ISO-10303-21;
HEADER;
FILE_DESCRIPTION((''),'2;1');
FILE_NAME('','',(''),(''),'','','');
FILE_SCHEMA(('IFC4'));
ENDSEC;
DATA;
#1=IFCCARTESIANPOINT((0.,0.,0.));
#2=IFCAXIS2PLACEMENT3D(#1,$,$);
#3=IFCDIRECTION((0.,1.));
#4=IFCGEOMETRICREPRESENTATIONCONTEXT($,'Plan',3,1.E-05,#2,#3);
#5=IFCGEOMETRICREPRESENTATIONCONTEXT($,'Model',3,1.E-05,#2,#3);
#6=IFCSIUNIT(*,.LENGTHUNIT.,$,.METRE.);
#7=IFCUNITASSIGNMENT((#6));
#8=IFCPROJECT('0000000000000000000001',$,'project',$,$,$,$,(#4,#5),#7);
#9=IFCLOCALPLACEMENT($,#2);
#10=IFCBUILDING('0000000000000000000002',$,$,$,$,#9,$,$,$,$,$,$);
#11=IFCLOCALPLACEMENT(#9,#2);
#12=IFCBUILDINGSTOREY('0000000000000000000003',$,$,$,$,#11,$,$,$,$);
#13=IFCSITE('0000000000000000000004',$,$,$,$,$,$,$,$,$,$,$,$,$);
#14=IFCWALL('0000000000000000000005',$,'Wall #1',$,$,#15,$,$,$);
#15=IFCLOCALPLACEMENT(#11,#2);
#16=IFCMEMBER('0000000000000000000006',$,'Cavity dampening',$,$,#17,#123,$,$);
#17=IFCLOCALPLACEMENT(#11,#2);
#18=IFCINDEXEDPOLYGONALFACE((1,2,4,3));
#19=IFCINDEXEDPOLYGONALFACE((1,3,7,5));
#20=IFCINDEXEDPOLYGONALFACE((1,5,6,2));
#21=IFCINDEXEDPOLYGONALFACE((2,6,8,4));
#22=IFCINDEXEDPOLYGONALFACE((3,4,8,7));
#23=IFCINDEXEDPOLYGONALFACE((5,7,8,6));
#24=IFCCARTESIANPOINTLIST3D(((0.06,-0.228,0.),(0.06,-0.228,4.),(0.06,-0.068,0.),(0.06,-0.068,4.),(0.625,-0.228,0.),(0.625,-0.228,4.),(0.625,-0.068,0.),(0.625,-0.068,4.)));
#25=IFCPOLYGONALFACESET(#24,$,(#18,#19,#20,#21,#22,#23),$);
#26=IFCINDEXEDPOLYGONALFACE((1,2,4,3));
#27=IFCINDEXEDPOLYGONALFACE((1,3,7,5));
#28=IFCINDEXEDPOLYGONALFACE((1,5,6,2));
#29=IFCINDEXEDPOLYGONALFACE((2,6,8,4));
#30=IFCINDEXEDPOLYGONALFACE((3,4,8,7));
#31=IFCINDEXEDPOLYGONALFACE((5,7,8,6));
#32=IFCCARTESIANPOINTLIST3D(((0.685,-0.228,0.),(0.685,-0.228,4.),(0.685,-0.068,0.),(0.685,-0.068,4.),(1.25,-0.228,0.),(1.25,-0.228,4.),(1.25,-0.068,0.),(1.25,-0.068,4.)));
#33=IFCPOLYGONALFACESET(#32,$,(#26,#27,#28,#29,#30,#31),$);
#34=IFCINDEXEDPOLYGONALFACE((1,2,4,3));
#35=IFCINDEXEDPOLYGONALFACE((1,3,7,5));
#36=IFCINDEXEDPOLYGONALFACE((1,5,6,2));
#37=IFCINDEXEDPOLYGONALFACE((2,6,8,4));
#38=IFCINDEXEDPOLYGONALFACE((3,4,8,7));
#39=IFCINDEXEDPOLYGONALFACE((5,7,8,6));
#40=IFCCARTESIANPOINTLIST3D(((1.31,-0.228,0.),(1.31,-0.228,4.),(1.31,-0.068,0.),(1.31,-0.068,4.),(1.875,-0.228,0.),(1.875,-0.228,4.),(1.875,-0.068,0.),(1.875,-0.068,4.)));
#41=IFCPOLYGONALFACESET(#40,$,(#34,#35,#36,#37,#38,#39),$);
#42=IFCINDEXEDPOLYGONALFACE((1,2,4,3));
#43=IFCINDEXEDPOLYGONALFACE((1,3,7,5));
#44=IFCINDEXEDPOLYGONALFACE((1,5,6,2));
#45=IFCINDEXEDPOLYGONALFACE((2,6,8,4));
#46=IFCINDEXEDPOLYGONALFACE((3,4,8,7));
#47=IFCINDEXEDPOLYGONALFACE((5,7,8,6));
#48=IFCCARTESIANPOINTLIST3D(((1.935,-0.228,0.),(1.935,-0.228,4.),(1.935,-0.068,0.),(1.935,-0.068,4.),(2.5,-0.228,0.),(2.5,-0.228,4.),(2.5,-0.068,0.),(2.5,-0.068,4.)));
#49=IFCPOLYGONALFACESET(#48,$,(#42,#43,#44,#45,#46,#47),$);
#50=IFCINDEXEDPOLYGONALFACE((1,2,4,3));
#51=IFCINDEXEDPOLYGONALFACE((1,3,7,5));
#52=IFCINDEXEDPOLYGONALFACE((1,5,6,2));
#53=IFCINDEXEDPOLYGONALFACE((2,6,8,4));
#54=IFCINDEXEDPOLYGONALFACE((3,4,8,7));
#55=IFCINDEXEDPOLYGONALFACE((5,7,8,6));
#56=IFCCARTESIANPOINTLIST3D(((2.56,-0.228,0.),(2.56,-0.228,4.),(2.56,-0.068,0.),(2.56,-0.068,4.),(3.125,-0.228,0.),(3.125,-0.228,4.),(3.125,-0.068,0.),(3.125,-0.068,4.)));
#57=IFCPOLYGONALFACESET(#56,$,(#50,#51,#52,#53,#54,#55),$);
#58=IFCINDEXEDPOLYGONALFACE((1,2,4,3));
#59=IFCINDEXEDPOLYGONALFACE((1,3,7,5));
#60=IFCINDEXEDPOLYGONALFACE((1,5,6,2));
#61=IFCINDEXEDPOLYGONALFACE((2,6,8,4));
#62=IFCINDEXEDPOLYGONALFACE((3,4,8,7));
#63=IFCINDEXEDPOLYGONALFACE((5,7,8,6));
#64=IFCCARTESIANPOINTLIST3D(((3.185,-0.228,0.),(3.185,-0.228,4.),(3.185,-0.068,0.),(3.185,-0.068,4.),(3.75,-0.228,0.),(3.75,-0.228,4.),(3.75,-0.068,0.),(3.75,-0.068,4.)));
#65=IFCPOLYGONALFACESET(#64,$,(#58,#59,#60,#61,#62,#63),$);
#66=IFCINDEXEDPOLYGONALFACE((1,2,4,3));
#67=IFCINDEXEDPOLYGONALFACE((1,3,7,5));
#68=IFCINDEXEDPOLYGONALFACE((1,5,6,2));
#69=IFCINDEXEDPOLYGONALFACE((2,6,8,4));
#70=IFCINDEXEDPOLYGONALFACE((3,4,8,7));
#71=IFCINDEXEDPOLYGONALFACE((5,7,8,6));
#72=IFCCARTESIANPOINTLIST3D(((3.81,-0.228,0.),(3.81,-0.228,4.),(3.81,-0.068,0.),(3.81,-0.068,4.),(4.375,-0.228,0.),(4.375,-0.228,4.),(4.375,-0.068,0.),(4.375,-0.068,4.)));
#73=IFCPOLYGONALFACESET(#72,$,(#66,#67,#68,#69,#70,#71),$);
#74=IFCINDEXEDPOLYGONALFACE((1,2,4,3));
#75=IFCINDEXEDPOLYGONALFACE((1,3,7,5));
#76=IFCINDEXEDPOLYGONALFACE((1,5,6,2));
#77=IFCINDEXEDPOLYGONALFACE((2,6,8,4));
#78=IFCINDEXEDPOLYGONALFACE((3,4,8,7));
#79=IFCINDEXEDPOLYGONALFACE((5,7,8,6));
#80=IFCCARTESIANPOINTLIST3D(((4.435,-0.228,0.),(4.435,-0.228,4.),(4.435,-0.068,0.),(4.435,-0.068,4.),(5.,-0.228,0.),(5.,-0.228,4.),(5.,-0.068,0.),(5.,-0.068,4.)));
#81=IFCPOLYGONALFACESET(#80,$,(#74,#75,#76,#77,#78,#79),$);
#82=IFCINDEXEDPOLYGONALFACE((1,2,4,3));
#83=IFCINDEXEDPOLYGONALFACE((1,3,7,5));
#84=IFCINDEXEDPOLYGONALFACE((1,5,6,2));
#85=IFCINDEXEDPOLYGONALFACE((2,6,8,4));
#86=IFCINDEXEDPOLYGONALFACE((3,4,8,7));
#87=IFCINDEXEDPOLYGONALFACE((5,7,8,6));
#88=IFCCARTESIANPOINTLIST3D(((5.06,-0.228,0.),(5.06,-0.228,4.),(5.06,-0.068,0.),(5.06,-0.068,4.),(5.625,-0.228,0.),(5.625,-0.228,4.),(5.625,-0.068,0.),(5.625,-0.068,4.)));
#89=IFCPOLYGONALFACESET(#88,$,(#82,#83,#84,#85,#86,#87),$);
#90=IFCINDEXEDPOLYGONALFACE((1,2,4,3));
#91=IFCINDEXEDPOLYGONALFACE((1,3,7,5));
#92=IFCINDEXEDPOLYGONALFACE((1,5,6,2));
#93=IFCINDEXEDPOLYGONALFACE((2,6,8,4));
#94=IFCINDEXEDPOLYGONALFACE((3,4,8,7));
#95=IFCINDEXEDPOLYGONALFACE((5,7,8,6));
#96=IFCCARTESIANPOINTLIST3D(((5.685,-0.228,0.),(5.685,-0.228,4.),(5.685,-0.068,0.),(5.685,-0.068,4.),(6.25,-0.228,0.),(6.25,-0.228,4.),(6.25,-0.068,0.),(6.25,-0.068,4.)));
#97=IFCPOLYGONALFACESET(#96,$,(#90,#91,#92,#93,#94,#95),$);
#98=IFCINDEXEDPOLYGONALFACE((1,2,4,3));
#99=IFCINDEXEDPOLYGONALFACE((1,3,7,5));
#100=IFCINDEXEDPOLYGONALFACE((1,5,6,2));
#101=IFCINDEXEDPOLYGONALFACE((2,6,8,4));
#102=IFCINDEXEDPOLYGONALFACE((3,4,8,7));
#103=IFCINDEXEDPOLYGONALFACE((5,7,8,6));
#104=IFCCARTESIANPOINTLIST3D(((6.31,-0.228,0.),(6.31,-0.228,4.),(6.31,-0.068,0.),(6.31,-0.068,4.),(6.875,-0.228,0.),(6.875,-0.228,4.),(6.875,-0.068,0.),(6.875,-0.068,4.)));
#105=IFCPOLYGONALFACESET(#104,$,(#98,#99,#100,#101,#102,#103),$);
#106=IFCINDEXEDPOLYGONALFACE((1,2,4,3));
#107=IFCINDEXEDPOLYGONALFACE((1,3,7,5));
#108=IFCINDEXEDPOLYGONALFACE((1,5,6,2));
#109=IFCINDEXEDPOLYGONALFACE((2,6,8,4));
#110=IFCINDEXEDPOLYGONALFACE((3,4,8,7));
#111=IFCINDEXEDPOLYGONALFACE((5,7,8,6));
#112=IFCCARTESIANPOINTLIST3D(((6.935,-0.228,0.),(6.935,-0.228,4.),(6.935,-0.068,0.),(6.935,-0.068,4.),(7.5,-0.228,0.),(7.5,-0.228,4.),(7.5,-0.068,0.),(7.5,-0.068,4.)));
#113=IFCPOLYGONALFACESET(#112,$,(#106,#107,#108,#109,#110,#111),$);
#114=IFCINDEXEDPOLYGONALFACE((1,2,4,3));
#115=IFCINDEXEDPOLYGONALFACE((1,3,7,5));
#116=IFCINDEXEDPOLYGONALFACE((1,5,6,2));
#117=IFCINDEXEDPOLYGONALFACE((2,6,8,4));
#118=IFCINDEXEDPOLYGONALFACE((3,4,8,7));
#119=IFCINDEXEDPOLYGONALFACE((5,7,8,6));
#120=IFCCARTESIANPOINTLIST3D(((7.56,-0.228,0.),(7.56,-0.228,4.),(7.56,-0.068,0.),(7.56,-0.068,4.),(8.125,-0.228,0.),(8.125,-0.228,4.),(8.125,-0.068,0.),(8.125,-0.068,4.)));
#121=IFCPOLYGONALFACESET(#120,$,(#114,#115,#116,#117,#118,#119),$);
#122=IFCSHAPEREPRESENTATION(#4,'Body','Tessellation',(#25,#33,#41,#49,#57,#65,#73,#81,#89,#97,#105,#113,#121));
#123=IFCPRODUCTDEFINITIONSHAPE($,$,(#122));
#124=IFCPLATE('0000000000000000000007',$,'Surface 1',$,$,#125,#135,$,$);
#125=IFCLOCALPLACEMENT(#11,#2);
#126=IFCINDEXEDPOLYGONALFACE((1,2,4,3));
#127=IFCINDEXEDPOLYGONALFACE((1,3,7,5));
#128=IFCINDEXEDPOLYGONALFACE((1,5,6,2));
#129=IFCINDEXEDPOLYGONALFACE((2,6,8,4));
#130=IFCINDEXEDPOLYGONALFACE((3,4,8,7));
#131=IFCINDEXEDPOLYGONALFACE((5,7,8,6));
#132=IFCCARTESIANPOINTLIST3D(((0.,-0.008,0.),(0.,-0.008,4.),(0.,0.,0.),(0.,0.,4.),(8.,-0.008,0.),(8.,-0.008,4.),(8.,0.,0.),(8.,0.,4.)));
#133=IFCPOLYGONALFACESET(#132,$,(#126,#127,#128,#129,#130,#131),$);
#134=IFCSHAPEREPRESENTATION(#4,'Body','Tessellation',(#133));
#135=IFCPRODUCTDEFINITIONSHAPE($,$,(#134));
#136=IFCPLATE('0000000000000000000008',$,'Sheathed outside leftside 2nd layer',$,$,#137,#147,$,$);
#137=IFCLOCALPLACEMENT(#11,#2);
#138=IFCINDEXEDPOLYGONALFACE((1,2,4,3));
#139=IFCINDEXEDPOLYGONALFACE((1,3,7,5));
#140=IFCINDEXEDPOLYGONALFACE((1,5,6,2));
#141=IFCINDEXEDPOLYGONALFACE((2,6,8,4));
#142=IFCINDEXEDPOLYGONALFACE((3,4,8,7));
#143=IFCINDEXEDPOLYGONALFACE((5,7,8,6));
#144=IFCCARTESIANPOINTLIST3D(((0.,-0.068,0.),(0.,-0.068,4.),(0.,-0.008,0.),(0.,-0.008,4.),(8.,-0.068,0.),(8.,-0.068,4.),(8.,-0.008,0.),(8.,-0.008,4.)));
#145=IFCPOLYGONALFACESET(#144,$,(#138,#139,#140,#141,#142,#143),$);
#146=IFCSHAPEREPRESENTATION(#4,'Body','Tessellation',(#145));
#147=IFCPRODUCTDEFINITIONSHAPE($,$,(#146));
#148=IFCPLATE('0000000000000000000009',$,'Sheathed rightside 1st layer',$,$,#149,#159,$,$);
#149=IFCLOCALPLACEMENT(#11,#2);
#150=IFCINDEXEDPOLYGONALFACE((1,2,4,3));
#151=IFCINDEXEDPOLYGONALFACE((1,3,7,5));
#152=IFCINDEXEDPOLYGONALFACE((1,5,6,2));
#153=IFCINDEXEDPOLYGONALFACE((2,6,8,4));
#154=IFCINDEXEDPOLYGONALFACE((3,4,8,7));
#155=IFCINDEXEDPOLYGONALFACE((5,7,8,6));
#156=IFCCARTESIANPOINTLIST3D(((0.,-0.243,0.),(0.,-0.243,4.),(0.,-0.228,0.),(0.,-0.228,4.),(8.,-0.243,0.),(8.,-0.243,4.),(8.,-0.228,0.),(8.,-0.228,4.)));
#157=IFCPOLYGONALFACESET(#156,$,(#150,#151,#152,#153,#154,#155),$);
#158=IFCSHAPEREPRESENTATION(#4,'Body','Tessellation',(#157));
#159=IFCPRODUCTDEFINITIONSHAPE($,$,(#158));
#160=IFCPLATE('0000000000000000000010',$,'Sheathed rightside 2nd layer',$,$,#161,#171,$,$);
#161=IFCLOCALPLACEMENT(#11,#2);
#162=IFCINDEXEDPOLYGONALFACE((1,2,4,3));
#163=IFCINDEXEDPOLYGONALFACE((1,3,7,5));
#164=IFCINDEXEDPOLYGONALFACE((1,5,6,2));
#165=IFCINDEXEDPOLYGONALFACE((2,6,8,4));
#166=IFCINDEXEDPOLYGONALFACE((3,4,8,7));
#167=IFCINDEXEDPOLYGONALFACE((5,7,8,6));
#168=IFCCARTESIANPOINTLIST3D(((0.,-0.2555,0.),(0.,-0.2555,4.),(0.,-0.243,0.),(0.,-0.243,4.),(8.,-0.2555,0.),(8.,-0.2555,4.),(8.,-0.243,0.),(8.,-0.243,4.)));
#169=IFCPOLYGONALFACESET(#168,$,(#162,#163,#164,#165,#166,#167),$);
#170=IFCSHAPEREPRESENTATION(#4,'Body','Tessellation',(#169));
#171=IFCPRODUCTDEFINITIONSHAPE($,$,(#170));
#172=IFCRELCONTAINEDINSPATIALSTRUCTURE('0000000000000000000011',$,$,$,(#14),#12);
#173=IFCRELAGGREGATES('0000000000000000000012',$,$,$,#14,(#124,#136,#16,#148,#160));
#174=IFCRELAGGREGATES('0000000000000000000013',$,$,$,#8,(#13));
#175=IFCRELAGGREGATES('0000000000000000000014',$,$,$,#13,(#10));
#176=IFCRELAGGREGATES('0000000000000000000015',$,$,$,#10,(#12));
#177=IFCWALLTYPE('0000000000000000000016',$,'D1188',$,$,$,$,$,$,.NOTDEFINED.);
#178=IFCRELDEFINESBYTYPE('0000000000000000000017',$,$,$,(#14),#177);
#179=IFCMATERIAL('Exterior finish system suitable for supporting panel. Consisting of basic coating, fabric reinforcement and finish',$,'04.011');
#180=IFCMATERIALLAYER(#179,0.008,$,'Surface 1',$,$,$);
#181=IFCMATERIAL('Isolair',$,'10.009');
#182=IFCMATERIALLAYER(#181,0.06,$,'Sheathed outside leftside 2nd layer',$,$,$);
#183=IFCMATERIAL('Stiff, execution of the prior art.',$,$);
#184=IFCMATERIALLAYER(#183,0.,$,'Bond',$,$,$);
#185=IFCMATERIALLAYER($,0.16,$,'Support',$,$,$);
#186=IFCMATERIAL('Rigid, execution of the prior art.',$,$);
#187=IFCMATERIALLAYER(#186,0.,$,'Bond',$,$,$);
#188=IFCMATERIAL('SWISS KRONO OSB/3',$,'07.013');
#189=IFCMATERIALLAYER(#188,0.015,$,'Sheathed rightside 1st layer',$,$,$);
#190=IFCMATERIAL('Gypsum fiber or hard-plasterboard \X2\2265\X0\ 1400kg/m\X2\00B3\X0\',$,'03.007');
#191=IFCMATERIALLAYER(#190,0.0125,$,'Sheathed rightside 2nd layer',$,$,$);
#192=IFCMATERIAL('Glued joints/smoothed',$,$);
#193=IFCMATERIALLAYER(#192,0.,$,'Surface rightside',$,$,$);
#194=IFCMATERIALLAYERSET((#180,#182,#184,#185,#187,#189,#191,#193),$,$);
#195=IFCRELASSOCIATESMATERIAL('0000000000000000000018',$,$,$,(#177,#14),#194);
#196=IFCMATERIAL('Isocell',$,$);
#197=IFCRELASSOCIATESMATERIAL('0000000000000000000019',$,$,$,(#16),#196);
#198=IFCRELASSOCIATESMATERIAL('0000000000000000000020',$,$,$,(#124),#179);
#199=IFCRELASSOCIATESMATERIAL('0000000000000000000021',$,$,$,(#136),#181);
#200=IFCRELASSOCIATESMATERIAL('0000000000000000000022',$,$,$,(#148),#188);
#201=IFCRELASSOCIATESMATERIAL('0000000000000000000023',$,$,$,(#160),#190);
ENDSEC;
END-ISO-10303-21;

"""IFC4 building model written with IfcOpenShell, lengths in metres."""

from ifc_helpers import new_model, si_unit, direction, frame, frame_2d, origin, origin_with_axes, place, context, project, spatial, rectangle, extrude, material, layer, layer_set, type_object, element, aggregate, save


model = new_model("IFC4")

# Units and contexts
plan_context = context("Plan", 3, precision=1e-05, world=origin(), true_north=direction((0.0, 1.0)))
model_context = context("Model", 3, precision=1e-05, world=origin(), true_north=direction((0.0, 1.0)))
ifc_project = project(units=[si_unit("LENGTHUNIT", "METRE")], contexts=[plan_context, model_context])

# Site, building, storey
site = spatial("IfcSite", under=ifc_project)
building_placement = place(None, origin())
building = spatial("IfcBuilding", under=site, at=building_placement)
storey_placement = place(building_placement, origin())
storey = spatial("IfcBuildingStorey", under=building, at=storey_placement)

# Wall, member, plates
ifc_material_1 = material(Name="Exterior finish system suitable for supporting panel. Consisting of basic coating, fabric reinforcement and finish", Category="04.011")
ifc_layer_1 = layer(ifc_material_1, 0.008, Name="Surface 1")
ifc_material_2 = material(Name="Isolair", Category="10.009")
ifc_layer_2 = layer(ifc_material_2, 0.06, Name="Sheathed outside leftside 2nd layer")
ifc_material_3 = material(Name="Stiff, execution of the prior art.")
ifc_layer_3 = layer(ifc_material_3, 0.0, Name="Bond")
ifc_layer_4 = layer(None, 0.16, Name="Support")
ifc_material_4 = material(Name="Rigid, execution of the prior art.")
ifc_layer_5 = layer(ifc_material_4, 0.0, Name="Bond")
ifc_material_5 = material(Name="SWISS KRONO OSB/3", Category="07.013")
ifc_layer_6 = layer(ifc_material_5, 0.015, Name="Sheathed rightside 1st layer")
ifc_material_6 = material(Name="Gypsum fiber or hard-plasterboard ≥ 1400kg/m³", Category="03.007")
ifc_layer_7 = layer(ifc_material_6, 0.0125, Name="Sheathed rightside 2nd layer")
ifc_material_7 = material(Name="Glued joints/smoothed")
ifc_layer_8 = layer(ifc_material_7, 0.0, Name="Surface rightside")
ifc_layer_set = layer_set([ifc_layer_1, ifc_layer_2, ifc_layer_3, ifc_layer_4, ifc_layer_5, ifc_layer_6, ifc_layer_7, ifc_layer_8])
wall_type = type_object("IfcWallType", Name="D1188", PredefinedType="NOTDEFINED", material=ifc_layer_set)
wall_placement = place(None, frame((0.0, 0.0, 0.0), z_axis=(0.0, -1.0, 0.0), x_axis=(1.0, 0.0, 0.0)))
wall = element("IfcWall", 1, at=wall_placement, inside=storey, type_object=wall_type, material=ifc_layer_set, Name="Wall #1")
ifc_material_8 = material(Name="Isocell")
member_1_placement = place(wall_placement, origin())
member_1 = element("IfcMember", 2, at=member_1_placement, material=ifc_material_8, Name="Cavity dampening", context=plan_context, shape_type="SweptSolid", body=[
    extrude(rectangle(XDim=0.565, YDim=0.16, at=frame_2d((0.2825, 0.08), x_axis=(1.0, 0.0))), frame((0.06, 4.0, 0.068), z_axis=(0.0, -1.0, 0.0), x_axis=(1.0, 0.0, 0.0)), (0.0, 0.0, 1.0), 4.0),
    extrude(rectangle(XDim=0.565, YDim=0.16, at=frame_2d((0.2825, 0.08), x_axis=(1.0, 0.0))), frame((0.685, 4.0, 0.068), z_axis=(0.0, -1.0, 0.0), x_axis=(1.0, 0.0, 0.0)), (0.0, 0.0, 1.0), 4.0),
    extrude(rectangle(XDim=0.565, YDim=0.16, at=frame_2d((0.2825, 0.08), x_axis=(1.0, 0.0))), frame((1.31, 4.0, 0.068), z_axis=(0.0, -1.0, 0.0), x_axis=(1.0, 0.0, 0.0)), (0.0, 0.0, 1.0), 4.0),
    extrude(rectangle(XDim=0.565, YDim=0.16, at=frame_2d((0.2825, 0.08), x_axis=(1.0, 0.0))), frame((1.935, 4.0, 0.068), z_axis=(0.0, -1.0, 0.0), x_axis=(1.0, 0.0, 0.0)), (0.0, 0.0, 1.0), 4.0),
    extrude(rectangle(XDim=0.565, YDim=0.16, at=frame_2d((0.2825, 0.08), x_axis=(1.0, 0.0))), frame((2.56, 4.0, 0.068), z_axis=(0.0, -1.0, 0.0), x_axis=(1.0, 0.0, 0.0)), (0.0, 0.0, 1.0), 4.0),
    extrude(rectangle(XDim=0.565, YDim=0.16, at=frame_2d((0.2825, 0.08), x_axis=(1.0, 0.0))), frame((3.185, 4.0, 0.068), z_axis=(0.0, -1.0, 0.0), x_axis=(1.0, 0.0, 0.0)), (0.0, 0.0, 1.0), 4.0),
    extrude(rectangle(XDim=0.565, YDim=0.16, at=frame_2d((0.2825, 0.08), x_axis=(1.0, 0.0))), frame((3.81, 4.0, 0.068), z_axis=(0.0, -1.0, 0.0), x_axis=(1.0, 0.0, 0.0)), (0.0, 0.0, 1.0), 4.0),
    extrude(rectangle(XDim=0.565, YDim=0.16, at=frame_2d((0.2825, 0.08), x_axis=(1.0, 0.0))), frame((4.435, 4.0, 0.068), z_axis=(0.0, -1.0, 0.0), x_axis=(1.0, 0.0, 0.0)), (0.0, 0.0, 1.0), 4.0),
    extrude(rectangle(XDim=0.565, YDim=0.16, at=frame_2d((0.2825, 0.08), x_axis=(1.0, 0.0))), frame((5.06, 4.0, 0.068), z_axis=(0.0, -1.0, 0.0), x_axis=(1.0, 0.0, 0.0)), (0.0, 0.0, 1.0), 4.0),
    extrude(rectangle(XDim=0.565, YDim=0.16, at=frame_2d((0.2825, 0.08), x_axis=(1.0, 0.0))), frame((5.685, 4.0, 0.068), z_axis=(0.0, -1.0, 0.0), x_axis=(1.0, 0.0, 0.0)), (0.0, 0.0, 1.0), 4.0),
    extrude(rectangle(XDim=0.565, YDim=0.16, at=frame_2d((0.2825, 0.08), x_axis=(1.0, 0.0))), frame((6.31, 4.0, 0.068), z_axis=(0.0, -1.0, 0.0), x_axis=(1.0, 0.0, 0.0)), (0.0, 0.0, 1.0), 4.0),
    extrude(rectangle(XDim=0.565, YDim=0.16, at=frame_2d((0.2825, 0.08), x_axis=(1.0, 0.0))), frame((6.935, 4.0, 0.068), z_axis=(0.0, -1.0, 0.0), x_axis=(1.0, 0.0, 0.0)), (0.0, 0.0, 1.0), 4.0),
    extrude(rectangle(XDim=0.565, YDim=0.16, at=frame_2d((0.2825, 0.08), x_axis=(1.0, 0.0))), frame((7.56, 4.0, 0.068), z_axis=(0.0, -1.0, 0.0), x_axis=(1.0, 0.0, 0.0)), (0.0, 0.0, 1.0), 4.0),
])
plate_1_placement = place(wall_placement, origin())
plate_1 = element("IfcPlate", 3, at=plate_1_placement, material=ifc_material_1, Name="Surface 1", context=plan_context, shape_type="SweptSolid", body=[
    extrude(rectangle(XDim=8.0, YDim=4.0, at=frame_2d((4.0, 2.0), x_axis=(1.0, 0.0))), origin_with_axes(), (0.0, 0.0, 1.0), 0.008),
])
plate_2_placement = place(wall_placement, origin())
plate_2 = element("IfcPlate", 4, at=plate_2_placement, material=ifc_material_2, Name="Sheathed outside leftside 2nd layer", context=plan_context, shape_type="SweptSolid", body=[
    extrude(rectangle(XDim=8.0, YDim=4.0, at=frame_2d((4.0, 2.0), x_axis=(1.0, 0.0))), frame((0.0, 0.0, 0.008), z_axis=(0.0, 0.0, 1.0), x_axis=(1.0, 0.0, 0.0)), (0.0, 0.0, 1.0), 0.06),
])
plate_3_placement = place(wall_placement, origin())
plate_3 = element("IfcPlate", 5, at=plate_3_placement, material=ifc_material_5, Name="Sheathed rightside 1st layer", context=plan_context, shape_type="SweptSolid", body=[
    extrude(rectangle(XDim=8.0, YDim=4.0, at=frame_2d((4.0, 2.0), x_axis=(1.0, 0.0))), frame((0.0, 0.0, 0.228), z_axis=(0.0, 0.0, 1.0), x_axis=(1.0, 0.0, 0.0)), (0.0, 0.0, 1.0), 0.015),
])
plate_4_placement = place(wall_placement, origin())
plate_4 = element("IfcPlate", 6, at=plate_4_placement, material=ifc_material_6, Name="Sheathed rightside 2nd layer", context=plan_context, shape_type="SweptSolid", body=[
    extrude(rectangle(XDim=8.0, YDim=4.0, at=frame_2d((4.0, 2.0), x_axis=(1.0, 0.0))), frame((0.0, 0.0, 0.243), z_axis=(0.0, 0.0, 1.0), x_axis=(1.0, 0.0, 0.0)), (0.0, 0.0, 1.0), 0.0125),
])
aggregate(wall, [plate_1, plate_2, member_1, plate_3, plate_4])

save(model, "model.ifc")
